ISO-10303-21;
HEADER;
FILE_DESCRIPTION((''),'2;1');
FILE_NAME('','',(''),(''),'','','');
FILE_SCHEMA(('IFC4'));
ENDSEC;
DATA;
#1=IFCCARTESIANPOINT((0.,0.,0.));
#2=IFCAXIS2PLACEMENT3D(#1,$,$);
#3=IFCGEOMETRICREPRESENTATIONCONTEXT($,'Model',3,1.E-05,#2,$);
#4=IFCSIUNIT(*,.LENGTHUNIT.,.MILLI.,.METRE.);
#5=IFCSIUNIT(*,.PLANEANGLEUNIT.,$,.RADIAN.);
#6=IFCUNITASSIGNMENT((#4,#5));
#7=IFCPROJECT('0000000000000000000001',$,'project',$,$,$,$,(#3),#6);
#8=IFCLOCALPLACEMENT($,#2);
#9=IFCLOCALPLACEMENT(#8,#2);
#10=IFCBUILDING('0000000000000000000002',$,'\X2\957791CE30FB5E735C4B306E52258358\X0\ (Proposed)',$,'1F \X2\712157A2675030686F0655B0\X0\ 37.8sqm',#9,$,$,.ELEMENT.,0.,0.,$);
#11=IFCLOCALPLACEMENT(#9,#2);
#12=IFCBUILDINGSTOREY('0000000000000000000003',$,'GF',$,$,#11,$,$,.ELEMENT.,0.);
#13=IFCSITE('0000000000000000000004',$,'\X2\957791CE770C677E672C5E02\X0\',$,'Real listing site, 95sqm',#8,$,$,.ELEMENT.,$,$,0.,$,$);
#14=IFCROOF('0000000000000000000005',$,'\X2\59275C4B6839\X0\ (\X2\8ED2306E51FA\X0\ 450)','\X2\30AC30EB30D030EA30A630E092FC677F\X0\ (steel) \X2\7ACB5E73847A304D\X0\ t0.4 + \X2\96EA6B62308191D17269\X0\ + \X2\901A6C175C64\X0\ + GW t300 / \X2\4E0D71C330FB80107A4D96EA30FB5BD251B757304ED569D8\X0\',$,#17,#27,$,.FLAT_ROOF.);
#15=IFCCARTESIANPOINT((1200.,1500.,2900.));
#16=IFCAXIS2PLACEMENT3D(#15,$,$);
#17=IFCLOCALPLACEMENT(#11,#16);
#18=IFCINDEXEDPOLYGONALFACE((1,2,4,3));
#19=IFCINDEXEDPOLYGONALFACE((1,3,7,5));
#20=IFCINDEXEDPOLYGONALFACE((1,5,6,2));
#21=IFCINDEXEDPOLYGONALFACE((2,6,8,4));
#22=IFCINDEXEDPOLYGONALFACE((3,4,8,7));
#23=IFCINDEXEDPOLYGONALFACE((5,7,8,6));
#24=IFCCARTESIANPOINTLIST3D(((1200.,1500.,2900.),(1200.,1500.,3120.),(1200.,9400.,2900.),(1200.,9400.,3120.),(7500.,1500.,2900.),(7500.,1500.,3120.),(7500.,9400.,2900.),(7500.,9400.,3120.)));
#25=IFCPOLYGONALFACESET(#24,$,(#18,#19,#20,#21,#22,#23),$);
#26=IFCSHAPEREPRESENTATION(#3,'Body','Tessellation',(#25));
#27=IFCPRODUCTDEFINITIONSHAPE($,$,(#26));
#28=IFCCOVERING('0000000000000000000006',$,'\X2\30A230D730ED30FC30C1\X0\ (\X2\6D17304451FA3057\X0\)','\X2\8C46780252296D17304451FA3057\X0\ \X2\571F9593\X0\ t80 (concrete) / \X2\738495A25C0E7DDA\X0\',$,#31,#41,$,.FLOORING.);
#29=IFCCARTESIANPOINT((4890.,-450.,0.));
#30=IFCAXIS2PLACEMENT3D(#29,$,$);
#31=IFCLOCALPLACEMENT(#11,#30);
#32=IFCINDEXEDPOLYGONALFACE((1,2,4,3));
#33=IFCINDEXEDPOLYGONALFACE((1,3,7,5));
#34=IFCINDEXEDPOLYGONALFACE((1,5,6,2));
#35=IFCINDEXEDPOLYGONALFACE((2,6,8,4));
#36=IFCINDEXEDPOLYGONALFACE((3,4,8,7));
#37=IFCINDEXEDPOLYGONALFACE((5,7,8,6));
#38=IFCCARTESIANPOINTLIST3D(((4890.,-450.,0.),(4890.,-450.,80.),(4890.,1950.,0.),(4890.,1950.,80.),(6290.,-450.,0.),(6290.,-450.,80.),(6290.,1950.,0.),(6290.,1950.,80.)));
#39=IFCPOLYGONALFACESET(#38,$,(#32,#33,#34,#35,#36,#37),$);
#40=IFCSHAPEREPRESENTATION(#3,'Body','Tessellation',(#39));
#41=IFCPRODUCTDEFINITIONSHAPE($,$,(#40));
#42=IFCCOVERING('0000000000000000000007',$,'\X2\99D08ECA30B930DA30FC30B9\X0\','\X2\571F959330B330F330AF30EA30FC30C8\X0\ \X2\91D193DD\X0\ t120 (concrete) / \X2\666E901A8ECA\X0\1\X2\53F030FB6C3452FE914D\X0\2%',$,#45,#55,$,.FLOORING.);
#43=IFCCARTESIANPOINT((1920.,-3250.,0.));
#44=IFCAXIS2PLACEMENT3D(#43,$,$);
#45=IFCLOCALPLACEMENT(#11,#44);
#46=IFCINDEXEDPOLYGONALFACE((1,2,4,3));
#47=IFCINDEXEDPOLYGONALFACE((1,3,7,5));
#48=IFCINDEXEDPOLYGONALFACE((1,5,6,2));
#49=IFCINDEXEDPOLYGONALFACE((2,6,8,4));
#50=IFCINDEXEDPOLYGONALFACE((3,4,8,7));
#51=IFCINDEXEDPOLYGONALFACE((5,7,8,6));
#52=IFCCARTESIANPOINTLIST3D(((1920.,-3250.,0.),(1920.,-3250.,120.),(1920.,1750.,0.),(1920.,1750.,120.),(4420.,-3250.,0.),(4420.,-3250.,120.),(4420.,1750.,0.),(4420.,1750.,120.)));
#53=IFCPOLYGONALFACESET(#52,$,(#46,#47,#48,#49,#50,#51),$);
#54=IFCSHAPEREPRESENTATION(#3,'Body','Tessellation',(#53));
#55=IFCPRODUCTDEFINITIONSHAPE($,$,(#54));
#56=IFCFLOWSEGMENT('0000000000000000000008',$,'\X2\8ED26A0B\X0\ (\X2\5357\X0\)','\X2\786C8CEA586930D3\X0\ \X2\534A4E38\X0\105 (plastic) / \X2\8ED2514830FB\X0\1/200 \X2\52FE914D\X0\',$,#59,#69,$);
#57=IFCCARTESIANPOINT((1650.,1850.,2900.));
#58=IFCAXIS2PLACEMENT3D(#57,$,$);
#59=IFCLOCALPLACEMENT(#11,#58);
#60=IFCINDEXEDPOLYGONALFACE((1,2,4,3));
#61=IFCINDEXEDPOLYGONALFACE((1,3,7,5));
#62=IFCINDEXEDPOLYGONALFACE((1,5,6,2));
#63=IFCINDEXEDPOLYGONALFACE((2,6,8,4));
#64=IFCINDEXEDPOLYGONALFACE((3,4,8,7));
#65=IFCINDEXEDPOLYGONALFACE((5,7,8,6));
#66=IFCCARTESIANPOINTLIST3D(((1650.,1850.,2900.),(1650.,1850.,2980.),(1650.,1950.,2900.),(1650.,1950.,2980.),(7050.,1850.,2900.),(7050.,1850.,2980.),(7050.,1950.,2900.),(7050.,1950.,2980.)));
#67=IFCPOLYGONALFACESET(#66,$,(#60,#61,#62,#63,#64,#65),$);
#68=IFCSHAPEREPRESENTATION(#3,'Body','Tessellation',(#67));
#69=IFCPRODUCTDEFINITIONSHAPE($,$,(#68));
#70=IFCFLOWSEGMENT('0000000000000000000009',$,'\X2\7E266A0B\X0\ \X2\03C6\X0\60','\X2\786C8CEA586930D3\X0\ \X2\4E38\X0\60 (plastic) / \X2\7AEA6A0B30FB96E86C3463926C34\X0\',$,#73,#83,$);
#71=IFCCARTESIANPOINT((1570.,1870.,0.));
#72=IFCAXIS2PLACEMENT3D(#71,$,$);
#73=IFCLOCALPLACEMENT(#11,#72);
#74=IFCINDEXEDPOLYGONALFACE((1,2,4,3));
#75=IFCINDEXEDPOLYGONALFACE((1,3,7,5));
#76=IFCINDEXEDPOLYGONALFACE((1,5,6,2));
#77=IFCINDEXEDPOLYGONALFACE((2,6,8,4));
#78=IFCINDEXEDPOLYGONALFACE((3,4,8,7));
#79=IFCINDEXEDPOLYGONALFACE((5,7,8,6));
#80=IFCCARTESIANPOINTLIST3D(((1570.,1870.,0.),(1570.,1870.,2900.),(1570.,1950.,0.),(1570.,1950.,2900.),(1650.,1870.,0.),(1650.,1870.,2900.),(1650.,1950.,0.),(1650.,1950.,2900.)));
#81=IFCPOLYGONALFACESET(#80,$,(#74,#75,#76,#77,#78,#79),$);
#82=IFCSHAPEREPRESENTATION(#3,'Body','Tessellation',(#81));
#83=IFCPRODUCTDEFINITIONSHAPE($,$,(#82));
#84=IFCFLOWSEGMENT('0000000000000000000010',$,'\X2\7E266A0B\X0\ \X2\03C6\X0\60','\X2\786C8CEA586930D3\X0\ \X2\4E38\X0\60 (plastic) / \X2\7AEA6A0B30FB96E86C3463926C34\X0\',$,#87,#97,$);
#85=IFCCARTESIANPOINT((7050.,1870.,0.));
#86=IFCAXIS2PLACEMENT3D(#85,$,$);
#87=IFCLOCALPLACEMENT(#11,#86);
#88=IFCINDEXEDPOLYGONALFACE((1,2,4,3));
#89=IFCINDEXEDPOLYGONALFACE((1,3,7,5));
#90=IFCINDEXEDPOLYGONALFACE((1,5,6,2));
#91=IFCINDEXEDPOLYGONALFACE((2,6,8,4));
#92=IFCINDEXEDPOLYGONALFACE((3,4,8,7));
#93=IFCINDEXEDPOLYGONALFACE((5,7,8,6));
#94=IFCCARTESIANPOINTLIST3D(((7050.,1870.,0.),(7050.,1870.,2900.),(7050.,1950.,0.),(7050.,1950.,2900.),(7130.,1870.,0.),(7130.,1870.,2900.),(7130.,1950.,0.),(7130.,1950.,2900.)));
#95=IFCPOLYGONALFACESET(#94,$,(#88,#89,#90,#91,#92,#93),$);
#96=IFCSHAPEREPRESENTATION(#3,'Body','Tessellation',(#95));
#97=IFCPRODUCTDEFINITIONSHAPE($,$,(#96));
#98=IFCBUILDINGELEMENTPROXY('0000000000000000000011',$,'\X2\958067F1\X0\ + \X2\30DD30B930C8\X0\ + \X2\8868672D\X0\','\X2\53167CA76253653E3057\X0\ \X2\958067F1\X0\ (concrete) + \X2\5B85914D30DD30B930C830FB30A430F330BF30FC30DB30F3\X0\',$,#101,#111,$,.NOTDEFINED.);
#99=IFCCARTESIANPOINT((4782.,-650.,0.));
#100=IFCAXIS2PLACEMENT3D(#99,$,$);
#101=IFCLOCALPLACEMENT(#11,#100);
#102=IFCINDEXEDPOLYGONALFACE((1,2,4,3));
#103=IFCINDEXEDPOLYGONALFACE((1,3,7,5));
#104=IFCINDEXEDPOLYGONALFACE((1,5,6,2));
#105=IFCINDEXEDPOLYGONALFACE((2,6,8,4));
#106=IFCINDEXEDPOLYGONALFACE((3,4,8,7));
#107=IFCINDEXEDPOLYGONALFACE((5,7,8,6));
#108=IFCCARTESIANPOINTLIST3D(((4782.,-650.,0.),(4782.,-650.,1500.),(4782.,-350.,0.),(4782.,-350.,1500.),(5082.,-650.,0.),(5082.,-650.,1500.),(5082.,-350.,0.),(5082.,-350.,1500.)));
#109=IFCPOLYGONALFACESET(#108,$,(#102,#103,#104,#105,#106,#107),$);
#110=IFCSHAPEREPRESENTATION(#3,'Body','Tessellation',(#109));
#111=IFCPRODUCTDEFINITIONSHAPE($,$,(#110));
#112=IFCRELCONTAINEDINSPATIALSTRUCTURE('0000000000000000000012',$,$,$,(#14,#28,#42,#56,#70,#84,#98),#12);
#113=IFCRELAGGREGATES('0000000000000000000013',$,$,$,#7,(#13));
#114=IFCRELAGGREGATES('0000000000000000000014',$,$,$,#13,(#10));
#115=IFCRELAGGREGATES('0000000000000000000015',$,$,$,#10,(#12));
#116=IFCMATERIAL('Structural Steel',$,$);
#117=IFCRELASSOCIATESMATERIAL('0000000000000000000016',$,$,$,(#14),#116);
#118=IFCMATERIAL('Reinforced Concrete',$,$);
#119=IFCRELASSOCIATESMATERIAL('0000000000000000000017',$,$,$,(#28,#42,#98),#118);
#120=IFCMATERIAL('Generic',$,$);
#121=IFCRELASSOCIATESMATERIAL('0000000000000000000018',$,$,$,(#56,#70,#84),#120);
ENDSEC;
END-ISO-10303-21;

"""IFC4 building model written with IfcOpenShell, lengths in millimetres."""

from ifc_helpers import new_model, si_unit, frame, frame_2d, origin, place, context, project, spatial, rectangle, extrude, material, element, save


model = new_model("IFC4")

# Units and contexts
model_context = context("Model", 3, precision=1e-05, world=origin())
ifc_project = project(units=[si_unit("LENGTHUNIT", "METRE", prefix="MILLI"), si_unit("PLANEANGLEUNIT", "RADIAN")], contexts=[model_context])

# Site, building, storey
site_placement = place(None, origin())
site = spatial("IfcSite", under=ifc_project, at=site_placement, Name="長野県松本市", ObjectType="Real listing site, 95sqm", CompositionType="ELEMENT", RefElevation=0.0)
building_placement = place(site_placement, origin())
building = spatial("IfcBuilding", under=site, at=building_placement, Name="長野・平屋の別荘 (Proposed)", ObjectType="1F 無垢材と漆喰 37.8sqm", CompositionType="ELEMENT", ElevationOfRefHeight=0.0, ElevationOfTerrain=0.0)
storey_placement = place(building_placement, origin())
storey = spatial("IfcBuildingStorey", under=building, at=storey_placement, Name="GF", CompositionType="ELEMENT", Elevation=0.0)

# Shared definitions
ifc_material_1 = material(Name="Reinforced Concrete")

# Roof
ifc_material_2 = material(Name="Structural Steel")
roof_placement = place(storey_placement, frame((1200.0, 1500.0, 2900.0)))
element("IfcRoof", 1, at=roof_placement, inside=storey, material=ifc_material_2, Name="大屋根 (軒の出 450)", Description="ガルバリウム鋼板 (steel) 立平葺き t0.4 + 雪止め金物 + 通気層 + GW t300 / 不燃・耐積雪・寒冷地仕様", PredefinedType="FLAT_ROOF", context=model_context, shape_type="SweptSolid", body=[
    extrude(rectangle(XDim=6300.0, YDim=7900.0, at=frame_2d((3150.0, 3950.0))), frame((1200.0, 1500.0, 2900.0)), (0.0, 0.0, 1.0), 220.0),
])

# Coverings
covering_1_placement = place(storey_placement, frame((4890.0, -450.0, 0.0)))
element("IfcCovering", 2, at=covering_1_placement, inside=storey, material=ifc_material_1, Name="アプローチ (洗い出し)", Description="豆砂利洗い出し 土間 t80 (concrete) / 玄関導線", PredefinedType="FLOORING", context=model_context, shape_type="SweptSolid", body=[
    extrude(rectangle(XDim=1400.0, YDim=2400.0, at=frame_2d((700.0, 1200.0))), frame((4890.0, -450.0, 0.0)), (0.0, 0.0, 1.0), 80.0),
])
covering_2_placement = place(storey_placement, frame((1920.0, -3250.0, 0.0)))
element("IfcCovering", 3, at=covering_2_placement, inside=storey, material=ifc_material_1, Name="駐車スペース", Description="土間コンクリート 金鏝 t120 (concrete) / 普通車1台・水勾配2%", PredefinedType="FLOORING", context=model_context, shape_type="SweptSolid", body=[
    extrude(rectangle(XDim=2500.0, YDim=5000.0, at=frame_2d((1250.0, 2500.0))), frame((1920.0, -3250.0, 0.0)), (0.0, 0.0, 1.0), 120.0),
])

# Flow segments
ifc_material_3 = material(Name="Generic")
flow_segment_1_placement = place(storey_placement, frame((1650.0, 1850.0, 2900.0)))
element("IfcFlowSegment", 4, at=flow_segment_1_placement, inside=storey, material=ifc_material_3, Name="軒樋 (南)", Description="硬質塩ビ 半丸105 (plastic) / 軒先・1/200 勾配", context=model_context, shape_type="SweptSolid", body=[
    extrude(rectangle(XDim=5400.0, YDim=100.0, at=frame_2d((2700.0, 50.0))), frame((1650.0, 1850.0, 2900.0)), (0.0, 0.0, 1.0), 80.0),
])
flow_segment_2_placement = place(storey_placement, frame((1570.0, 1870.0, 0.0)))
element("IfcFlowSegment", 5, at=flow_segment_2_placement, inside=storey, material=ifc_material_3, Name="縦樋 φ60", Description="硬質塩ビ 丸60 (plastic) / 竪樋・雨水排水", context=model_context, shape_type="SweptSolid", body=[
    extrude(rectangle(XDim=80.0, YDim=80.0, at=frame_2d((40.0, 40.0))), frame((1570.0, 1870.0, 0.0)), (0.0, 0.0, 1.0), 2900.0),
])
flow_segment_3_placement = place(storey_placement, frame((7050.0, 1870.0, 0.0)))
element("IfcFlowSegment", 6, at=flow_segment_3_placement, inside=storey, material=ifc_material_3, Name="縦樋 φ60", Description="硬質塩ビ 丸60 (plastic) / 竪樋・雨水排水", context=model_context, shape_type="SweptSolid", body=[
    extrude(rectangle(XDim=80.0, YDim=80.0, at=frame_2d((40.0, 40.0))), frame((7050.0, 1870.0, 0.0)), (0.0, 0.0, 1.0), 2900.0),
])

# Building element proxy
proxy_placement = place(storey_placement, frame((4782.0, -650.0, 0.0)))
element("IfcBuildingElementProxy", 7, at=proxy_placement, inside=storey, material=ifc_material_1, Name="門柱 + ポスト + 表札", Description="化粧打放し 門柱 (concrete) + 宅配ポスト・インターホン", PredefinedType="NOTDEFINED", context=model_context, shape_type="SweptSolid", body=[
    extrude(rectangle(XDim=300.0, YDim=300.0, at=frame_2d((150.0, 150.0))), frame((4782.0, -650.0, 0.0)), (0.0, 0.0, 1.0), 1500.0),
])

save(model, "model.ifc")
